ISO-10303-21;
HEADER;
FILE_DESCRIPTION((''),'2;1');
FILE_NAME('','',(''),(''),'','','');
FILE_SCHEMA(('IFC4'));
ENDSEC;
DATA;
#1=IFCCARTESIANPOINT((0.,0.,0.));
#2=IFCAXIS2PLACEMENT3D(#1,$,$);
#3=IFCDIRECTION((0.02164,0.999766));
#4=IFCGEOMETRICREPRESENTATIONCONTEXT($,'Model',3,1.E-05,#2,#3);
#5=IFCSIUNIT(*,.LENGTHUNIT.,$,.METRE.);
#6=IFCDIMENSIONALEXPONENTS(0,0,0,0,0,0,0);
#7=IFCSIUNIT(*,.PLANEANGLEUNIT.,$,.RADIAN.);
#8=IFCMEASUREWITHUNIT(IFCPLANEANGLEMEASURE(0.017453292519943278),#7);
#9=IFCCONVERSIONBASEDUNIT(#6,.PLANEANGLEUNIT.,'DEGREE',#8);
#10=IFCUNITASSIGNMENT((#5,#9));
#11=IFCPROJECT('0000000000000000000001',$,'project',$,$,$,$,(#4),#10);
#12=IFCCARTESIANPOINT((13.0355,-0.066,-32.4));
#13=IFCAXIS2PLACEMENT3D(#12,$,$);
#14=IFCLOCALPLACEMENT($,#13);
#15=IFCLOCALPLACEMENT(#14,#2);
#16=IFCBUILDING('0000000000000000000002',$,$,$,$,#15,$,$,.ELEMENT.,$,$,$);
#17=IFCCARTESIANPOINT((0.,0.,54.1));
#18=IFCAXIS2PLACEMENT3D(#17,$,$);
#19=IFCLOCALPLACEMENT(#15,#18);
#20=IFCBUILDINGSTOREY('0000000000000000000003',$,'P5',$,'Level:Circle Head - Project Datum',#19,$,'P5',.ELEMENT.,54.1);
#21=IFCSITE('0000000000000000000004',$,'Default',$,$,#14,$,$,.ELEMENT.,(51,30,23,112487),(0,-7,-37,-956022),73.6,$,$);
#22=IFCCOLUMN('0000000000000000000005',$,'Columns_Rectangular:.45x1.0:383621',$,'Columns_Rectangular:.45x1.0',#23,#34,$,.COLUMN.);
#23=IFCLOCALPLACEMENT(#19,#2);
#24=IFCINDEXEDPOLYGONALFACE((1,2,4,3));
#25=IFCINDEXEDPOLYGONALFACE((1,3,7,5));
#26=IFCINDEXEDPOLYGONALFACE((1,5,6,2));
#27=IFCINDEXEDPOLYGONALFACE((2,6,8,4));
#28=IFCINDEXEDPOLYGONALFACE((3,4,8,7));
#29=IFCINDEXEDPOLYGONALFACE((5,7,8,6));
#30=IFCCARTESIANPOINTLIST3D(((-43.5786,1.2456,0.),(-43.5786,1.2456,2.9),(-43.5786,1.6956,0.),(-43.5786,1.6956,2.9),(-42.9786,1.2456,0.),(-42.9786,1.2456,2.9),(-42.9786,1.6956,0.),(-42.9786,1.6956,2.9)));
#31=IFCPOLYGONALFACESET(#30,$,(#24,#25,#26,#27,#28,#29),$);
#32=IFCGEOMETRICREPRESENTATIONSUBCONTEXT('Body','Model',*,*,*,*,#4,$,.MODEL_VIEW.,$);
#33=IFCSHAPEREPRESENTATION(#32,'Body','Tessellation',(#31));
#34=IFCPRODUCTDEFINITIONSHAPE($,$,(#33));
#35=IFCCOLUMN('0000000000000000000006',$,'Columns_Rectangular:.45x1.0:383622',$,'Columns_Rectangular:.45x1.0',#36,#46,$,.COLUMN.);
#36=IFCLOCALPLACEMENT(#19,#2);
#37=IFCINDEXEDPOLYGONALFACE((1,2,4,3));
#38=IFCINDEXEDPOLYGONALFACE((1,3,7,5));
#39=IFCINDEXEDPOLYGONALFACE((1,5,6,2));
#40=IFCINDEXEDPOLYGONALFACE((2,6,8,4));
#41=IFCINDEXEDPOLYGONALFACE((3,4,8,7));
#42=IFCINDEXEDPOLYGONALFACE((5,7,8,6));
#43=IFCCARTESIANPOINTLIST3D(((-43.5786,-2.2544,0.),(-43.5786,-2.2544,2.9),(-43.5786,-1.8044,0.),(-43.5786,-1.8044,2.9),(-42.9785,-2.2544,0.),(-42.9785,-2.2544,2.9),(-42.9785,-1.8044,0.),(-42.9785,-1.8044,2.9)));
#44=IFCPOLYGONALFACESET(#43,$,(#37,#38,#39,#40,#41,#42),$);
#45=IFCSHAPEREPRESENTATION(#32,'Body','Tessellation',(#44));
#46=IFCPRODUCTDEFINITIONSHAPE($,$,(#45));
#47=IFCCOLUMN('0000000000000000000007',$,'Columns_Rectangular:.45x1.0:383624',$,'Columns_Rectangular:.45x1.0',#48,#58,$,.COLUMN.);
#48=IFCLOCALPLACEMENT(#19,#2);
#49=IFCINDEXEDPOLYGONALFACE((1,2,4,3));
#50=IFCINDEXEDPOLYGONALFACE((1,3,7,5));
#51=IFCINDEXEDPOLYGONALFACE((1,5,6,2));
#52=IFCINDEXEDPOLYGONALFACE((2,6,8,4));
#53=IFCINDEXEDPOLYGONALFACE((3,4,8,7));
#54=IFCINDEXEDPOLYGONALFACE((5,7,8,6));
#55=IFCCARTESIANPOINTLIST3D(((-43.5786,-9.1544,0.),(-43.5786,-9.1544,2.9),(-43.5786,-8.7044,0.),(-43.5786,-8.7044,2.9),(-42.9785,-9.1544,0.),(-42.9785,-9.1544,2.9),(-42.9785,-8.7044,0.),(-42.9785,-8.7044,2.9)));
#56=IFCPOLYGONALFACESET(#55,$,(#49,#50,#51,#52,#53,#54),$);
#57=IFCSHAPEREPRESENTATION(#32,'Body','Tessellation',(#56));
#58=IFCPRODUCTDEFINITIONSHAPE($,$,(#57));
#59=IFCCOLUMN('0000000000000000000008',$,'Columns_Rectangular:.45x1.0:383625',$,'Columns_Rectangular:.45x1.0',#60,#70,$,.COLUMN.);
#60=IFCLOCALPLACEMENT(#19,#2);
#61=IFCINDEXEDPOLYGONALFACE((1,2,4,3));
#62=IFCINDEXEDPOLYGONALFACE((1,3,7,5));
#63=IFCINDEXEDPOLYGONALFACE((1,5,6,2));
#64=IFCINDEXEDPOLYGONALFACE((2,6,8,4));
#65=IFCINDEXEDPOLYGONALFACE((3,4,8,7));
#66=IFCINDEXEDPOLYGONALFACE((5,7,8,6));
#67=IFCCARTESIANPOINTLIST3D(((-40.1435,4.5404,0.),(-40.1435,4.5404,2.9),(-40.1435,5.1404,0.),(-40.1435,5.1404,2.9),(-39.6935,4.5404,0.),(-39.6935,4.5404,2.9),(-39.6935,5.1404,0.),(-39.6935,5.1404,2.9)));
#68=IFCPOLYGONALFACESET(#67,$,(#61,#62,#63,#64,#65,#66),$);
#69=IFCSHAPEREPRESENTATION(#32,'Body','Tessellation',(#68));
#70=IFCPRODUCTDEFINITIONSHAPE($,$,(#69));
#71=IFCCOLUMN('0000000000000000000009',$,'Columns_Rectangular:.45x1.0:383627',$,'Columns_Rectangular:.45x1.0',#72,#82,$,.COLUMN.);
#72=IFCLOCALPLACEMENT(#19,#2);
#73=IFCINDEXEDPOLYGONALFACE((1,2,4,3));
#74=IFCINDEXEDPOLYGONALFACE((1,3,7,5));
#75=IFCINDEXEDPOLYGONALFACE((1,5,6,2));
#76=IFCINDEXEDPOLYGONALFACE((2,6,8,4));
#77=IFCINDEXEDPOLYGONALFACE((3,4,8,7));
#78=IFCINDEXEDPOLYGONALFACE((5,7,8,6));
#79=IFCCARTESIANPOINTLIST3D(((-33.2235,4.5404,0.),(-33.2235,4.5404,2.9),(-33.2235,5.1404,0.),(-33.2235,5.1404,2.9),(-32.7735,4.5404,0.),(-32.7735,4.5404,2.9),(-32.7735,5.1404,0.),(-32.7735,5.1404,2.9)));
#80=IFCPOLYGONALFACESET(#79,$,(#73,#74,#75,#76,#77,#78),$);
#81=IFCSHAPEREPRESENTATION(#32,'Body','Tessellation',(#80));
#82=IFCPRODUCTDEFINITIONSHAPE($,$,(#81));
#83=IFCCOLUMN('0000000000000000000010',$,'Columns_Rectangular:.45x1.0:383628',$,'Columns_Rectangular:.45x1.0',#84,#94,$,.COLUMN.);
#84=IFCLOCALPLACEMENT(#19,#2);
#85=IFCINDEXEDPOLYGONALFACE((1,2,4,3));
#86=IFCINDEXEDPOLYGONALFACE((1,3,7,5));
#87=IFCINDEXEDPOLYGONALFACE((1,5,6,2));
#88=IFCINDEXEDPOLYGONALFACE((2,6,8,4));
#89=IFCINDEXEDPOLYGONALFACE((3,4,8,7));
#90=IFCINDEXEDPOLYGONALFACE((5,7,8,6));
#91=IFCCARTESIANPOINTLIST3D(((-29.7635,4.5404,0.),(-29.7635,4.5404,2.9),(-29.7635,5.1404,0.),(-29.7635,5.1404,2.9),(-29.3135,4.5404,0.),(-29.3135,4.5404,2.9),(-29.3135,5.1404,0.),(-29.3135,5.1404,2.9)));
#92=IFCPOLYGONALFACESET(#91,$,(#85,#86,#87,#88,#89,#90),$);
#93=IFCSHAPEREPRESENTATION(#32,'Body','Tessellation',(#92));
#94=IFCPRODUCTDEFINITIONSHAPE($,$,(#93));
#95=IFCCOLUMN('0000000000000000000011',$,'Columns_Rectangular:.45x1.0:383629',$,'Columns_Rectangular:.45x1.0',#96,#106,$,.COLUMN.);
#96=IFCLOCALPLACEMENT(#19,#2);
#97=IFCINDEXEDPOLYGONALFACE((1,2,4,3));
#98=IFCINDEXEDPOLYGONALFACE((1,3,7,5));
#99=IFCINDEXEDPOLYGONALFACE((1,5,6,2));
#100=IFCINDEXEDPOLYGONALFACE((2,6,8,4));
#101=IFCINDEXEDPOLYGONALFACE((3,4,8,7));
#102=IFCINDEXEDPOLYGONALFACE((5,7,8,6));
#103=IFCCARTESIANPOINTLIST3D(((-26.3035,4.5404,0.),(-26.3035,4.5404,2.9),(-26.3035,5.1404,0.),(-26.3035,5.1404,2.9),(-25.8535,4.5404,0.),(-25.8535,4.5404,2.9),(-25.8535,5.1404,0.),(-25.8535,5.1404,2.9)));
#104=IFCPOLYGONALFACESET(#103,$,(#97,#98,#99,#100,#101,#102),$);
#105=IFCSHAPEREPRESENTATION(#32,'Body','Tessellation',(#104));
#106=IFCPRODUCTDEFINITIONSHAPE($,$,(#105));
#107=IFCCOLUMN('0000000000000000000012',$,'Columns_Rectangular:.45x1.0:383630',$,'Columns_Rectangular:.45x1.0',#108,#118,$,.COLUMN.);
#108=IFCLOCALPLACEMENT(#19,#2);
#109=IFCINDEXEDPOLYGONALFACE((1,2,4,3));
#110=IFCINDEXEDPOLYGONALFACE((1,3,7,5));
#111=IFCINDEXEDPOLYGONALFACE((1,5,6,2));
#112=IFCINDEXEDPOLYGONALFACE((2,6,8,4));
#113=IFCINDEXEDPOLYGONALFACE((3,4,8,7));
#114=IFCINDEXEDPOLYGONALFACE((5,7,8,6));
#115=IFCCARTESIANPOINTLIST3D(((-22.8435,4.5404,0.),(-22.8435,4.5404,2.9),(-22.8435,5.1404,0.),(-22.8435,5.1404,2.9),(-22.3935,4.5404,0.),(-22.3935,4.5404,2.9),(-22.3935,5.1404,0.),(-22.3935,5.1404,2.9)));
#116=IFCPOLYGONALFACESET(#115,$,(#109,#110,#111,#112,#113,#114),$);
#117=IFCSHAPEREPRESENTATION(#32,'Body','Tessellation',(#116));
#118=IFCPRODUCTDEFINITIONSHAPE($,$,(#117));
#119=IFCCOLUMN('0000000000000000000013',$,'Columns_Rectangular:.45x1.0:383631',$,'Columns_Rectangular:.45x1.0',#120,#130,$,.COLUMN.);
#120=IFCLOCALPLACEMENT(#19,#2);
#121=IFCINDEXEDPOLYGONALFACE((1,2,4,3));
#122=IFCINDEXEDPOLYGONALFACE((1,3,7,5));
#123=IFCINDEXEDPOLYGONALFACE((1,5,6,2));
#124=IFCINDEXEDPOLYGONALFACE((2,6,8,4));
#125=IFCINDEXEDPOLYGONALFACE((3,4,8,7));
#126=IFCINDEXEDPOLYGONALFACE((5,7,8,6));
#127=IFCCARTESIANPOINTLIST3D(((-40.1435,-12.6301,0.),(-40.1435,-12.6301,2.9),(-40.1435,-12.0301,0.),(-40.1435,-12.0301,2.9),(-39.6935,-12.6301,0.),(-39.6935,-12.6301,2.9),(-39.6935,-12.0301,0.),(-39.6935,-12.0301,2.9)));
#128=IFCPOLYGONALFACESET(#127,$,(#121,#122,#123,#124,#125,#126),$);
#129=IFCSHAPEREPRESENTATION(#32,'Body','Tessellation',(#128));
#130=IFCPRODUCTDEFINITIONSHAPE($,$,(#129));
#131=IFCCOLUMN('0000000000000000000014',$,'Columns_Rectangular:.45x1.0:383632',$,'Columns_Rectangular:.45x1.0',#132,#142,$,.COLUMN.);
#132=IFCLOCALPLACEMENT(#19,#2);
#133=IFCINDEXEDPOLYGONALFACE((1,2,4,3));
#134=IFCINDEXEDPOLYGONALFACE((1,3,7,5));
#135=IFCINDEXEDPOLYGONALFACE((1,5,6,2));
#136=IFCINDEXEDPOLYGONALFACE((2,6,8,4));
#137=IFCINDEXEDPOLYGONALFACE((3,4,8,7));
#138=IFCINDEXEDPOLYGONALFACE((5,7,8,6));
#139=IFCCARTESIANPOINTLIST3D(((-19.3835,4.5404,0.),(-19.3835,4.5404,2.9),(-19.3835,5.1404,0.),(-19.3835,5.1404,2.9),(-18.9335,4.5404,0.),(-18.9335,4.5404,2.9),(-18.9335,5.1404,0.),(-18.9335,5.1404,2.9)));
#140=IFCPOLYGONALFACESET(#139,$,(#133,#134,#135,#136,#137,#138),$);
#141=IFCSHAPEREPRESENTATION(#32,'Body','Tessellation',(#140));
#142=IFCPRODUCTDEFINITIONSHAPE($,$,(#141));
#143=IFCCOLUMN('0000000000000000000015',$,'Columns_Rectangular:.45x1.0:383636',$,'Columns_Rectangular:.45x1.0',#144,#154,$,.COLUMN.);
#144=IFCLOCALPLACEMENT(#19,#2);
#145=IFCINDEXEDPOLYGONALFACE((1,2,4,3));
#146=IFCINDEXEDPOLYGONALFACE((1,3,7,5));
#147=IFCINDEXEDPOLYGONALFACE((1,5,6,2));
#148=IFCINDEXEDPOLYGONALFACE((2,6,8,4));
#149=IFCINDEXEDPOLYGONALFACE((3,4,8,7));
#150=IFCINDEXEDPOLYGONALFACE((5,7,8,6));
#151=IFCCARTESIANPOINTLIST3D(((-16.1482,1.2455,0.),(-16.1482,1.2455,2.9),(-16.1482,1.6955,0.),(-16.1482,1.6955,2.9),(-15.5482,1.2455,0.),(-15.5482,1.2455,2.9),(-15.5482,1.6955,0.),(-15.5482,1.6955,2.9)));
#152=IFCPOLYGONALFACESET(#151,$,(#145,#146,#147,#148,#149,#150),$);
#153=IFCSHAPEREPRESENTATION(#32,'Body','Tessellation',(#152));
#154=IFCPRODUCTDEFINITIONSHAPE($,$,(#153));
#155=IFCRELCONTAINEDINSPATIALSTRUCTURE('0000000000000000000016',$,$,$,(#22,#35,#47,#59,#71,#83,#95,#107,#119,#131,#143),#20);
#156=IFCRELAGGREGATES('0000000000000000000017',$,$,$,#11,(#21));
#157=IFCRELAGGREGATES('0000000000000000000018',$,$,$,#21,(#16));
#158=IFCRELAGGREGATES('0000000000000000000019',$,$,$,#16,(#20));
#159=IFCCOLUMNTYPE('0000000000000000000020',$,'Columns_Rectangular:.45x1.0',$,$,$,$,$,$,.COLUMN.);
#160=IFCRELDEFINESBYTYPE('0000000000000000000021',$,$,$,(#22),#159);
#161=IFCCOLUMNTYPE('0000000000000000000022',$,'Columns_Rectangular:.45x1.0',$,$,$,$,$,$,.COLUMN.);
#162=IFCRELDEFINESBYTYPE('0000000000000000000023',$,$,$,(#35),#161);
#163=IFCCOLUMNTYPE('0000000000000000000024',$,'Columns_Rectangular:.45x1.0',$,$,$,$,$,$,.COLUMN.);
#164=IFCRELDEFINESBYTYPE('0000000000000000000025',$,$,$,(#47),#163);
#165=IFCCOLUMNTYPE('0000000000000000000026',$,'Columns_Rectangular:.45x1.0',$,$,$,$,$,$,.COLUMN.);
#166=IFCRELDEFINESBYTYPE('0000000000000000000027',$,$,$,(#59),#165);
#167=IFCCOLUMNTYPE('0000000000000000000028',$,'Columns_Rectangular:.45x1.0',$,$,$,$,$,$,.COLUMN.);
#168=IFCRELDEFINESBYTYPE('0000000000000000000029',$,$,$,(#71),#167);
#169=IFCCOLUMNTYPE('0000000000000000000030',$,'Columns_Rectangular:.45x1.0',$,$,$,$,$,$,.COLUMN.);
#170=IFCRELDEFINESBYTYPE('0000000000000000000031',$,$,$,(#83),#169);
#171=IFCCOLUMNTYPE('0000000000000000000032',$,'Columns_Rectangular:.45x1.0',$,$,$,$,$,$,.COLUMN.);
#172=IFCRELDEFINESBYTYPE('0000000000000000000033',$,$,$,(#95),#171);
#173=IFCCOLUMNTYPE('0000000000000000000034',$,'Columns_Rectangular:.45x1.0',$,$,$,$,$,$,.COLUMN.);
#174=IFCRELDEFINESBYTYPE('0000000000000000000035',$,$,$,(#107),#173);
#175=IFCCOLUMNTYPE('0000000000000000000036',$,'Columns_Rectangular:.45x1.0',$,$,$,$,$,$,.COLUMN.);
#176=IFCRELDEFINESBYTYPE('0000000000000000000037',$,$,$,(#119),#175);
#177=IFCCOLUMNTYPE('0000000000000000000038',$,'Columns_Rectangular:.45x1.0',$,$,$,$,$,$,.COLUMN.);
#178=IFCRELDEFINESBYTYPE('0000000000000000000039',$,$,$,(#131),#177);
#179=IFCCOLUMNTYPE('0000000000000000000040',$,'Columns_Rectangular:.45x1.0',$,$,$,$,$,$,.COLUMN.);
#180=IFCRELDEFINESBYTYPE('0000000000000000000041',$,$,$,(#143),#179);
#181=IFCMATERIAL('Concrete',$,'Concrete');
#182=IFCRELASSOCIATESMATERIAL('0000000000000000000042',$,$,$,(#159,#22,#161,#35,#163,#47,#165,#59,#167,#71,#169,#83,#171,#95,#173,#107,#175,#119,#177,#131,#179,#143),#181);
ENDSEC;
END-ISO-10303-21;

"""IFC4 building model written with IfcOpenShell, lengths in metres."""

from ifc_helpers import new_model, entity, si_unit, converted_unit, direction, frame, origin, place, context, subcontext, project, spatial, indexed_curve, outline, extrude, source, transform, mapped, material, type_object, type_shapes, element, save


model = new_model("IFC4")

# Units and contexts
model_context = context("Model", 3, precision=1e-05, world=origin(), true_north=direction((0.02164, 0.999766)))
body_context = subcontext(model_context, "Body", "Model", "MODEL_VIEW")
ifc_project = project(units=[si_unit("LENGTHUNIT", "METRE"), converted_unit("PLANEANGLEUNIT", "DEGREE", entity("IfcPlaneAngleMeasure", 0.017453292519943278), si_unit("PLANEANGLEUNIT", "RADIAN"), dimensions=[0, 0, 0, 0, 0, 0, 0])], contexts=[model_context])

# Site, building, storey
site_placement = place(None, frame((13.0355, -0.066, -32.4)))
site = spatial("IfcSite", under=ifc_project, at=site_placement, Name="Default", CompositionType="ELEMENT", RefLatitude=(51, 30, 23, 112487), RefLongitude=(0, -7, -37, -956022), RefElevation=73.6)
building_placement = place(site_placement, origin())
building = spatial("IfcBuilding", under=site, at=building_placement, CompositionType="ELEMENT")
storey_placement = place(building_placement, frame((0.0, 0.0, 54.1)))
storey = spatial("IfcBuildingStorey", under=building, at=storey_placement, Name="P5", ObjectType="Level:Circle Head - Project Datum", LongName="P5", CompositionType="ELEMENT", Elevation=54.1)

# Columns
ifc_material = material(Name="Concrete", Category="Concrete")
column_type_1 = type_object("IfcColumnType", Name="Columns_Rectangular:.45x1.0", PredefinedType="COLUMN", material=ifc_material)
shared_shape_1 = source(origin(), body_context, "Body", "SweptSolid", [
    extrude(outline(indexed_curve([(-0.3, -0.225), (0.3, -0.225), (0.3, 0.225), (-0.3, 0.225), (-0.3, -0.225)], self_intersect=False)), frame((-43.2786, 1.4706, 54.1)), (0.0, 0.0, 1.0), 2.9),
])
type_shapes(column_type_1, [shared_shape_1])
column_1_placement = place(storey_placement, frame((0.0, 0.0, -54.1)))
element("IfcColumn", 1, at=column_1_placement, inside=storey, type_object=column_type_1, material=ifc_material, Name="Columns_Rectangular:.45x1.0:383621", ObjectType="Columns_Rectangular:.45x1.0", PredefinedType="COLUMN", context=body_context, shape_type="MappedRepresentation", body=[
    mapped(shared_shape_1, transform((0.0, 0.0, 0.0), scale=1.0)),
])
column_type_2 = type_object("IfcColumnType", Name="Columns_Rectangular:.45x1.0", PredefinedType="COLUMN", material=ifc_material)
shared_shape_2 = source(origin(), body_context, "Body", "SweptSolid", [
    extrude(outline(indexed_curve([(-0.3, -0.225), (0.3, -0.225), (0.3, 0.225), (-0.3, 0.225), (-0.3, -0.225)], self_intersect=False)), frame((-43.2785, -2.0294, 54.1)), (0.0, 0.0, 1.0), 2.9),
])
type_shapes(column_type_2, [shared_shape_2])
column_2_placement = place(storey_placement, frame((0.0, 0.0, -54.1)))
element("IfcColumn", 2, at=column_2_placement, inside=storey, type_object=column_type_2, material=ifc_material, Name="Columns_Rectangular:.45x1.0:383622", ObjectType="Columns_Rectangular:.45x1.0", PredefinedType="COLUMN", context=body_context, shape_type="MappedRepresentation", body=[
    mapped(shared_shape_2, transform((0.0, 0.0, 0.0), scale=1.0)),
])
column_type_3 = type_object("IfcColumnType", Name="Columns_Rectangular:.45x1.0", PredefinedType="COLUMN", material=ifc_material)
shared_shape_3 = source(origin(), body_context, "Body", "SweptSolid", [
    extrude(outline(indexed_curve([(-0.3, -0.225), (0.3, -0.225), (0.3, 0.225), (-0.3, 0.225), (-0.3, -0.225)], self_intersect=False)), frame((-43.2785, -8.9294, 54.1)), (0.0, 0.0, 1.0), 2.9),
])
type_shapes(column_type_3, [shared_shape_3])
column_3_placement = place(storey_placement, frame((0.0, 0.0, -54.1)))
element("IfcColumn", 3, at=column_3_placement, inside=storey, type_object=column_type_3, material=ifc_material, Name="Columns_Rectangular:.45x1.0:383624", ObjectType="Columns_Rectangular:.45x1.0", PredefinedType="COLUMN", context=body_context, shape_type="MappedRepresentation", body=[
    mapped(shared_shape_3, transform((0.0, 0.0, 0.0), scale=1.0)),
])
column_type_4 = type_object("IfcColumnType", Name="Columns_Rectangular:.45x1.0", PredefinedType="COLUMN", material=ifc_material)
shared_shape_4 = source(origin(), body_context, "Body", "SweptSolid", [
    extrude(outline(indexed_curve([(-0.3, -0.225), (0.3, -0.225), (0.3, 0.225), (-0.3, 0.225), (-0.3, -0.225)], self_intersect=False)), frame((-39.9185, 4.8404, 54.1), z_axis=(0.0, 0.0, 1.0), x_axis=(0.0, -1.0, 0.0)), (0.0, 0.0, 1.0), 2.9),
])
type_shapes(column_type_4, [shared_shape_4])
column_4_placement = place(storey_placement, frame((0.0, 0.0, -54.1)))
element("IfcColumn", 4, at=column_4_placement, inside=storey, type_object=column_type_4, material=ifc_material, Name="Columns_Rectangular:.45x1.0:383625", ObjectType="Columns_Rectangular:.45x1.0", PredefinedType="COLUMN", context=body_context, shape_type="MappedRepresentation", body=[
    mapped(shared_shape_4, transform((0.0, 0.0, 0.0), scale=1.0)),
])
column_type_5 = type_object("IfcColumnType", Name="Columns_Rectangular:.45x1.0", PredefinedType="COLUMN", material=ifc_material)
shared_shape_5 = source(origin(), body_context, "Body", "SweptSolid", [
    extrude(outline(indexed_curve([(-0.3, -0.225), (0.3, -0.225), (0.3, 0.225), (-0.3, 0.225), (-0.3, -0.225)], self_intersect=False)), frame((-32.9985, 4.8404, 54.1), z_axis=(0.0, 0.0, 1.0), x_axis=(0.0, -1.0, 0.0)), (0.0, 0.0, 1.0), 2.9),
])
type_shapes(column_type_5, [shared_shape_5])
column_5_placement = place(storey_placement, frame((0.0, 0.0, -54.1)))
element("IfcColumn", 5, at=column_5_placement, inside=storey, type_object=column_type_5, material=ifc_material, Name="Columns_Rectangular:.45x1.0:383627", ObjectType="Columns_Rectangular:.45x1.0", PredefinedType="COLUMN", context=body_context, shape_type="MappedRepresentation", body=[
    mapped(shared_shape_5, transform((0.0, 0.0, 0.0), scale=1.0)),
])
column_type_6 = type_object("IfcColumnType", Name="Columns_Rectangular:.45x1.0", PredefinedType="COLUMN", material=ifc_material)
shared_shape_6 = source(origin(), body_context, "Body", "SweptSolid", [
    extrude(outline(indexed_curve([(-0.3, -0.225), (0.3, -0.225), (0.3, 0.225), (-0.3, 0.225), (-0.3, -0.225)], self_intersect=False)), frame((-29.5385, 4.8404, 54.1), z_axis=(0.0, 0.0, 1.0), x_axis=(0.0, -1.0, 0.0)), (0.0, 0.0, 1.0), 2.9),
])
type_shapes(column_type_6, [shared_shape_6])
column_6_placement = place(storey_placement, frame((0.0, 0.0, -54.1)))
element("IfcColumn", 6, at=column_6_placement, inside=storey, type_object=column_type_6, material=ifc_material, Name="Columns_Rectangular:.45x1.0:383628", ObjectType="Columns_Rectangular:.45x1.0", PredefinedType="COLUMN", context=body_context, shape_type="MappedRepresentation", body=[
    mapped(shared_shape_6, transform((0.0, 0.0, 0.0), scale=1.0)),
])
column_type_7 = type_object("IfcColumnType", Name="Columns_Rectangular:.45x1.0", PredefinedType="COLUMN", material=ifc_material)
shared_shape_7 = source(origin(), body_context, "Body", "SweptSolid", [
    extrude(outline(indexed_curve([(-0.3, -0.225), (0.3, -0.225), (0.3, 0.225), (-0.3, 0.225), (-0.3, -0.225)], self_intersect=False)), frame((-26.0785, 4.8404, 54.1), z_axis=(0.0, 0.0, 1.0), x_axis=(0.0, -1.0, 0.0)), (0.0, 0.0, 1.0), 2.9),
])
type_shapes(column_type_7, [shared_shape_7])
column_7_placement = place(storey_placement, frame((0.0, 0.0, -54.1)))
element("IfcColumn", 7, at=column_7_placement, inside=storey, type_object=column_type_7, material=ifc_material, Name="Columns_Rectangular:.45x1.0:383629", ObjectType="Columns_Rectangular:.45x1.0", PredefinedType="COLUMN", context=body_context, shape_type="MappedRepresentation", body=[
    mapped(shared_shape_7, transform((0.0, 0.0, 0.0), scale=1.0)),
])
column_type_8 = type_object("IfcColumnType", Name="Columns_Rectangular:.45x1.0", PredefinedType="COLUMN", material=ifc_material)
shared_shape_8 = source(origin(), body_context, "Body", "SweptSolid", [
    extrude(outline(indexed_curve([(-0.3, -0.225), (0.3, -0.225), (0.3, 0.225), (-0.3, 0.225), (-0.3, -0.225)], self_intersect=False)), frame((-22.6185, 4.8404, 54.1), z_axis=(0.0, 0.0, 1.0), x_axis=(0.0, -1.0, 0.0)), (0.0, 0.0, 1.0), 2.9),
])
type_shapes(column_type_8, [shared_shape_8])
column_8_placement = place(storey_placement, frame((0.0, 0.0, -54.1)))
element("IfcColumn", 8, at=column_8_placement, inside=storey, type_object=column_type_8, material=ifc_material, Name="Columns_Rectangular:.45x1.0:383630", ObjectType="Columns_Rectangular:.45x1.0", PredefinedType="COLUMN", context=body_context, shape_type="MappedRepresentation", body=[
    mapped(shared_shape_8, transform((0.0, 0.0, 0.0), scale=1.0)),
])
column_type_9 = type_object("IfcColumnType", Name="Columns_Rectangular:.45x1.0", PredefinedType="COLUMN", material=ifc_material)
shared_shape_9 = source(origin(), body_context, "Body", "SweptSolid", [
    extrude(outline(indexed_curve([(-0.3, -0.225), (0.3, -0.225), (0.3, 0.225), (-0.3, 0.225), (-0.3, -0.225)], self_intersect=False)), frame((-39.9185, -12.3301, 54.1), z_axis=(0.0, 0.0, 1.0), x_axis=(0.000011, 1.0, 0.0)), (0.0, 0.0, 1.0), 2.9),
])
type_shapes(column_type_9, [shared_shape_9])
column_9_placement = place(storey_placement, frame((0.0, 0.0, -54.1)))
element("IfcColumn", 9, at=column_9_placement, inside=storey, type_object=column_type_9, material=ifc_material, Name="Columns_Rectangular:.45x1.0:383631", ObjectType="Columns_Rectangular:.45x1.0", PredefinedType="COLUMN", context=body_context, shape_type="MappedRepresentation", body=[
    mapped(shared_shape_9, transform((0.0, 0.0, 0.0), scale=1.0)),
])
column_type_10 = type_object("IfcColumnType", Name="Columns_Rectangular:.45x1.0", PredefinedType="COLUMN", material=ifc_material)
shared_shape_10 = source(origin(), body_context, "Body", "SweptSolid", [
    extrude(outline(indexed_curve([(-0.3, -0.225), (0.3, -0.225), (0.3, 0.225), (-0.3, 0.225), (-0.3, -0.225)], self_intersect=False)), frame((-19.1585, 4.8404, 54.1), z_axis=(0.0, 0.0, 1.0), x_axis=(0.0, -1.0, 0.0)), (0.0, 0.0, 1.0), 2.9),
])
type_shapes(column_type_10, [shared_shape_10])
column_10_placement = place(storey_placement, frame((0.0, 0.0, -54.1)))
element("IfcColumn", 10, at=column_10_placement, inside=storey, type_object=column_type_10, material=ifc_material, Name="Columns_Rectangular:.45x1.0:383632", ObjectType="Columns_Rectangular:.45x1.0", PredefinedType="COLUMN", context=body_context, shape_type="MappedRepresentation", body=[
    mapped(shared_shape_10, transform((0.0, 0.0, 0.0), scale=1.0)),
])
column_type_11 = type_object("IfcColumnType", Name="Columns_Rectangular:.45x1.0", PredefinedType="COLUMN", material=ifc_material)
shared_shape_11 = source(origin(), body_context, "Body", "SweptSolid", [
    extrude(outline(indexed_curve([(-0.3, -0.225), (0.3, -0.225), (0.3, 0.225), (-0.3, 0.225), (-0.3, -0.225)], self_intersect=False)), frame((-15.8482, 1.4705, 54.1), z_axis=(0.0, 0.0, 1.0), x_axis=(-1.0, 0.0, 0.0)), (0.0, 0.0, 1.0), 2.9),
])
type_shapes(column_type_11, [shared_shape_11])
column_11_placement = place(storey_placement, frame((0.0, 0.0, -54.1)))
element("IfcColumn", 11, at=column_11_placement, inside=storey, type_object=column_type_11, material=ifc_material, Name="Columns_Rectangular:.45x1.0:383636", ObjectType="Columns_Rectangular:.45x1.0", PredefinedType="COLUMN", context=body_context, shape_type="MappedRepresentation", body=[
    mapped(shared_shape_11, transform((0.0, 0.0, 0.0), scale=1.0)),
])

save(model, "model.ifc")
